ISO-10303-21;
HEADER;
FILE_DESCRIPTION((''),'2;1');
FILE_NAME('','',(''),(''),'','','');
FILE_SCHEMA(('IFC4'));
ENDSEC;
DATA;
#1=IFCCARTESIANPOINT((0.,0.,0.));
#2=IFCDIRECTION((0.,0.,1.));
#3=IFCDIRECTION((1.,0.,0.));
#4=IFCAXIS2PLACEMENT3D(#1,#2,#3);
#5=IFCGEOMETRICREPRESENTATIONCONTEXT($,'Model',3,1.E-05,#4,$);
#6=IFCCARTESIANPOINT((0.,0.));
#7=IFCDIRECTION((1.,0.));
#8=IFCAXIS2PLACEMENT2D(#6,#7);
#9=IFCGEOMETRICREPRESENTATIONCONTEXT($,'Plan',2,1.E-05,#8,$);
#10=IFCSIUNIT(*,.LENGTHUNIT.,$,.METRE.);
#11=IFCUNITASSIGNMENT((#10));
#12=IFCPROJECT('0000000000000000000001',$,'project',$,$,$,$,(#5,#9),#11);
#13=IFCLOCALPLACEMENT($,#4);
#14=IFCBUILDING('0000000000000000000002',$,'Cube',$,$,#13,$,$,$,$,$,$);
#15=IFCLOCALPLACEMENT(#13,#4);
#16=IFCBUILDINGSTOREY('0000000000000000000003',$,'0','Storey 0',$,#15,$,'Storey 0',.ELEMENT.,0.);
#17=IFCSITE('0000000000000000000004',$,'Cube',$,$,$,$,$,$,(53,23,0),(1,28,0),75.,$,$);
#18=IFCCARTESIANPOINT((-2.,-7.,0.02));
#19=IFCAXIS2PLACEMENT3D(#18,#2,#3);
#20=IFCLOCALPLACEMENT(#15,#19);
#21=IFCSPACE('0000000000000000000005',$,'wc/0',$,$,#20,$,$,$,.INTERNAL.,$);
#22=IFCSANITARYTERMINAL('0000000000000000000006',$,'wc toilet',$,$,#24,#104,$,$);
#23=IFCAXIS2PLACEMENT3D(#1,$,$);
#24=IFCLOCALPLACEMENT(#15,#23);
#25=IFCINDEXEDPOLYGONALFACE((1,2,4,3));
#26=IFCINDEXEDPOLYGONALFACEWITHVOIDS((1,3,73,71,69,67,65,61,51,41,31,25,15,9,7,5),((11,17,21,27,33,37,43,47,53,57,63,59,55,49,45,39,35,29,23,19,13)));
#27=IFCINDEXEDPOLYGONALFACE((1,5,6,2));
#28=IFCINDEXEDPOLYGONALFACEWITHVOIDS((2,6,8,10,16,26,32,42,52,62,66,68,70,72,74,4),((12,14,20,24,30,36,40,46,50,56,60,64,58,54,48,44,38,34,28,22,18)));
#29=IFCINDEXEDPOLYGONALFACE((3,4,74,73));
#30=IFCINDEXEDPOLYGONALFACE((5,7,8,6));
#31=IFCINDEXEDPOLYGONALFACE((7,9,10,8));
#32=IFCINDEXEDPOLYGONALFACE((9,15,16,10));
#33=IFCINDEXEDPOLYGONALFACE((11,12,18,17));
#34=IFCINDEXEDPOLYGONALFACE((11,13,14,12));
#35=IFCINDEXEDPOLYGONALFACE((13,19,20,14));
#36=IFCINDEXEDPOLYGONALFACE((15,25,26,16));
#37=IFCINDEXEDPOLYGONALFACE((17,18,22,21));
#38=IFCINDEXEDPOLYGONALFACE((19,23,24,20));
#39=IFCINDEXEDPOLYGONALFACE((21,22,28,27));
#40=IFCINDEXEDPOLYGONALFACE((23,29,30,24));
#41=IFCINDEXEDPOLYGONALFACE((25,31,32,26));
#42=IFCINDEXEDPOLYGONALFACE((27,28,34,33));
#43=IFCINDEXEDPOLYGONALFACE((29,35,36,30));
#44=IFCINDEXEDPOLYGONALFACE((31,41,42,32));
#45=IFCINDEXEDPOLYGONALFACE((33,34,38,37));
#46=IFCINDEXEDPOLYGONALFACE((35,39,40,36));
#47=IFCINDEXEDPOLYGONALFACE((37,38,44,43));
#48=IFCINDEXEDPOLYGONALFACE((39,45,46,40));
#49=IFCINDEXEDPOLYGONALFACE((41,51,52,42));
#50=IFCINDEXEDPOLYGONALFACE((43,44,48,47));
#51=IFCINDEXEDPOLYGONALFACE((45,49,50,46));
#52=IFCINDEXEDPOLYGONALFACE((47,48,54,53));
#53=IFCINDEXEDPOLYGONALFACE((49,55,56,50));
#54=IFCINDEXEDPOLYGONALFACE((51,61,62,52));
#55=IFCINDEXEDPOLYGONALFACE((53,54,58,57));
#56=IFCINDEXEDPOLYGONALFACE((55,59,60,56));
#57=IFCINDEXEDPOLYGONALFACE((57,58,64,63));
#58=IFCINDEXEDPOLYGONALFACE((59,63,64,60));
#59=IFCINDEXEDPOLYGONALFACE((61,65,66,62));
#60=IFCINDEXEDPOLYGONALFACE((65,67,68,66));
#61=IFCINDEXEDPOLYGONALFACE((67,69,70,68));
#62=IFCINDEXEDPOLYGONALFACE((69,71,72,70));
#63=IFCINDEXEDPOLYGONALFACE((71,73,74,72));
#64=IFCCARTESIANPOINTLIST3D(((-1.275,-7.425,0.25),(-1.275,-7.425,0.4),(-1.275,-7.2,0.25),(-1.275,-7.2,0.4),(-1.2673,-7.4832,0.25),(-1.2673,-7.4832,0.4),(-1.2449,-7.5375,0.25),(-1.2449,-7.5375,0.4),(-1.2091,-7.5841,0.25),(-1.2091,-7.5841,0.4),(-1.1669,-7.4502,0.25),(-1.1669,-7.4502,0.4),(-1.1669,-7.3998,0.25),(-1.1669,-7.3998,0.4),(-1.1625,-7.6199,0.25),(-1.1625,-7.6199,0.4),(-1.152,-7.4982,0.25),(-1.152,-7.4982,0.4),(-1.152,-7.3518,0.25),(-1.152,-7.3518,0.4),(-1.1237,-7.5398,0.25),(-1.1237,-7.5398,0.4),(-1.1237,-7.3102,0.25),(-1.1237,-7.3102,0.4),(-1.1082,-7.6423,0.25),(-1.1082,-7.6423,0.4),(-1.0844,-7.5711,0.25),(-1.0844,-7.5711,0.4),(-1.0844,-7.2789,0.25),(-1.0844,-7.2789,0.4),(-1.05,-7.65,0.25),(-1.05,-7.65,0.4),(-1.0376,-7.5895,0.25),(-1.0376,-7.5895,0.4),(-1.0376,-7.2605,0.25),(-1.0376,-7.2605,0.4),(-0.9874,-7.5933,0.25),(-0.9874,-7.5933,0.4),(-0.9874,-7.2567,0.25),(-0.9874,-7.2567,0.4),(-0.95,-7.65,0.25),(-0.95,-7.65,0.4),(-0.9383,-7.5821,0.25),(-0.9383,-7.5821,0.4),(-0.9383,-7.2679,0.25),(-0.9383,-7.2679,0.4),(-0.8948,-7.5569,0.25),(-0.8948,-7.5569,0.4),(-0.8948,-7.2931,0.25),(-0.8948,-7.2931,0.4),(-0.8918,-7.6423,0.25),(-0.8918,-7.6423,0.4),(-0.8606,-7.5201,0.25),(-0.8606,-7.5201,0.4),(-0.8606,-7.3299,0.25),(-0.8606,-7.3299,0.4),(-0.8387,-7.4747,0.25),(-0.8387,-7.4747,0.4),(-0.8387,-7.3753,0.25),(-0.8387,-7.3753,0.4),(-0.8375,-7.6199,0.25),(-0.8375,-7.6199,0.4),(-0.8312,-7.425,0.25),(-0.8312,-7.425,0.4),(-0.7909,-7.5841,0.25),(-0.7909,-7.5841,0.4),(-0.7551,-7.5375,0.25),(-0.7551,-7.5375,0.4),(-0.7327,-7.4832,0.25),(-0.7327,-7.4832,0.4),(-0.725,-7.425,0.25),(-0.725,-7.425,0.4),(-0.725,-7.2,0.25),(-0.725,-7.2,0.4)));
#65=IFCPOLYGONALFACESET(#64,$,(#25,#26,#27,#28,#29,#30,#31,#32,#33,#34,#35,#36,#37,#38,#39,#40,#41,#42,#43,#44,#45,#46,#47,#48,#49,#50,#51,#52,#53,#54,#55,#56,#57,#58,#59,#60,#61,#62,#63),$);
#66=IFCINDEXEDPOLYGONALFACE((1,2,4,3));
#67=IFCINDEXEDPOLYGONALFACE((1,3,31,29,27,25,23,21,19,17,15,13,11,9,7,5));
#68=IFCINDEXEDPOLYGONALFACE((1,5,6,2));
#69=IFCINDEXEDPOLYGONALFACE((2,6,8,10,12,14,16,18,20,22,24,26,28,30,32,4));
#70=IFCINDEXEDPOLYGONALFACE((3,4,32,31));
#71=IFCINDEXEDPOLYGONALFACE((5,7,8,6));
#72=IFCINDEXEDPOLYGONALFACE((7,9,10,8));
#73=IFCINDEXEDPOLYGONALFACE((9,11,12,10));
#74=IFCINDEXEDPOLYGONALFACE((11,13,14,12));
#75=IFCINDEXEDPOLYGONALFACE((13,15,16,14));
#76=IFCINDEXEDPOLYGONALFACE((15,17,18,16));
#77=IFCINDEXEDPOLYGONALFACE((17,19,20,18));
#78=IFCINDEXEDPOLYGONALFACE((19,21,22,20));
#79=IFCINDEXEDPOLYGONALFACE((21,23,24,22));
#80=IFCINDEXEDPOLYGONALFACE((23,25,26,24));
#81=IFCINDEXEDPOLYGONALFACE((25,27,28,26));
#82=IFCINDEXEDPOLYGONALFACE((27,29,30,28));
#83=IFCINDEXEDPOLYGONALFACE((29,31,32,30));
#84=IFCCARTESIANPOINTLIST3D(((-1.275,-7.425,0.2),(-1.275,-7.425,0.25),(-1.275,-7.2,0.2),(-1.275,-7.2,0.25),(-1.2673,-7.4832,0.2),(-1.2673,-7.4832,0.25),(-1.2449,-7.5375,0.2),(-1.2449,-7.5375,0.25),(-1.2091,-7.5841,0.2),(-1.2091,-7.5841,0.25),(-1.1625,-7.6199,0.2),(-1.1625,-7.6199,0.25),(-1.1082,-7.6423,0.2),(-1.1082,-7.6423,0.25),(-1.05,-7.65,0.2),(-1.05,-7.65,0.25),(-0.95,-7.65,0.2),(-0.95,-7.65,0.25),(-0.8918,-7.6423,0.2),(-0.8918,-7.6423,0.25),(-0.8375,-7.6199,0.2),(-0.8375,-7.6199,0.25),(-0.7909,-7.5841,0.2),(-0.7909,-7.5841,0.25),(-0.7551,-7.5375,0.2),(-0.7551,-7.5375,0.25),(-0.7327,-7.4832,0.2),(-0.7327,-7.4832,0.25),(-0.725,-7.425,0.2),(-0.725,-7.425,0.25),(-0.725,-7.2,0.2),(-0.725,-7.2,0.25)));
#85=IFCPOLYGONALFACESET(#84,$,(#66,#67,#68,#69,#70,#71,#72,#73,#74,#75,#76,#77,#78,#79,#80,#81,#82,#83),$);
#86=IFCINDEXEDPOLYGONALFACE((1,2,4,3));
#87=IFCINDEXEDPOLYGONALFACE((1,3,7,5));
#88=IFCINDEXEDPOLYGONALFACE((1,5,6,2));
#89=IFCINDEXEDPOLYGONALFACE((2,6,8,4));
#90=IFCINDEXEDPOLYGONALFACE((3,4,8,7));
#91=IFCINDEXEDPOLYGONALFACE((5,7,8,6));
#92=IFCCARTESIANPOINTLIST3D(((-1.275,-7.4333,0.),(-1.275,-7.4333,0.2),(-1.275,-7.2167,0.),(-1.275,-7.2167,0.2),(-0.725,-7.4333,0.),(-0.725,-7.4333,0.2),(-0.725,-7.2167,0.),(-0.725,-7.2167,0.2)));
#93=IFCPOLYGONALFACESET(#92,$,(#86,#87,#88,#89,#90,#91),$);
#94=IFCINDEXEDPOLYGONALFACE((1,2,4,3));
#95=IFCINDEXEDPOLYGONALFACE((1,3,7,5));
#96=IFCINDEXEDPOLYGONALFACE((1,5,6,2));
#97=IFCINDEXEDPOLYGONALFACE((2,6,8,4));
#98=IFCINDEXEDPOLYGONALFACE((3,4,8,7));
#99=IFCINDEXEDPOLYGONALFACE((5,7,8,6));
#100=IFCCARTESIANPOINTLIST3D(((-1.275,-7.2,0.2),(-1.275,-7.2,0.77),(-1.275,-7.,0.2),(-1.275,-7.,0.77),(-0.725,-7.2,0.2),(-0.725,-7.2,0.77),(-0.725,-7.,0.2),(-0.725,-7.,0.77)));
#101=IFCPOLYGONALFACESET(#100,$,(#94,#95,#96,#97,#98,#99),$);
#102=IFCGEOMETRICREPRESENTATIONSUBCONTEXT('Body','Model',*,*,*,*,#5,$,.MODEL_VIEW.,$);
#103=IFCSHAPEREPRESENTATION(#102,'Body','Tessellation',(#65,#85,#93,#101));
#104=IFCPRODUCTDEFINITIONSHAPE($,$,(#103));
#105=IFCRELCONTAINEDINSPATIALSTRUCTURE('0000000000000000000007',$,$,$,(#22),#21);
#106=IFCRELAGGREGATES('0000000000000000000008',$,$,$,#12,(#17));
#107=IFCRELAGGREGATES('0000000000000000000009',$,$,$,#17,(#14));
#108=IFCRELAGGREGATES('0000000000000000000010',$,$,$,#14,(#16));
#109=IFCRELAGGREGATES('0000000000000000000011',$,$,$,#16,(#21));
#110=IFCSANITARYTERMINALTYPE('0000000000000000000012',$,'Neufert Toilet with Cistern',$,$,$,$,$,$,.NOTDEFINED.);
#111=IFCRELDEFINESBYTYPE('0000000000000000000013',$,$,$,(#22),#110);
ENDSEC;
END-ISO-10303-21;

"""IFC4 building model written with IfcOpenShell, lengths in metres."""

from ifc_helpers import new_model, entity, si_unit, frame, frame_2d, origin_with_axes, origin_2d_with_axis, place, context, subcontext, project, spatial, line, arc, indexed_curve, circle_curve, outline, extrude, shape, source, transform, mapped, type_object, type_shapes, element, save


model = new_model("IFC4")

# Units and contexts
model_context = context("Model", 3, precision=1e-05, world=origin_with_axes())
plan_context = context("Plan", 2, precision=1e-05, world=origin_2d_with_axis())
body_context_1 = subcontext(model_context, "Body", "Model", "MODEL_VIEW")
body_context_2 = subcontext(plan_context, "Body", "Plan", "PLAN_VIEW")
ifc_project = project(units=[si_unit("LENGTHUNIT", "METRE")], contexts=[model_context, plan_context])

# Site, building, storey
site = spatial("IfcSite", under=ifc_project, Name="Cube", RefLatitude=(53, 23, 0), RefLongitude=(1, 28, 0), RefElevation=75.0)
building_placement = place(None, origin_with_axes())
building = spatial("IfcBuilding", under=site, at=building_placement, Name="Cube")
storey_placement = place(building_placement, origin_with_axes())
storey = spatial("IfcBuildingStorey", under=building, at=storey_placement, Name="0", Description="Storey 0", LongName="Storey 0", CompositionType="ELEMENT", Elevation=0.0)

# Shared definitions
space_1_placement = place(storey_placement, frame((-2.0, -7.0, 0.02), z_axis=(0.0, 0.0, 1.0), x_axis=(1.0, 0.0, 0.0)))
space_1 = spatial("IfcSpace", under=storey, at=space_1_placement, Name="wc/0", PredefinedType="INTERNAL")

# Sanitary terminal
sanitary_terminal_type_1 = type_object("IfcSanitaryTerminalType", Name="Neufert Toilet with Cistern", PredefinedType="NOTDEFINED")
shared_shape_1 = source(origin_with_axes(), body_context_1, "Body", "SweptSolid", [
    extrude(outline(indexed_curve([(-0.275, -0.2), (0.275, -0.2), (0.275, -0.425), (0.2091, -0.5841), (0.05, -0.65), (-0.05, -0.65), (-0.2091, -0.5841), (-0.275, -0.425)], segments=[line(1, 2), line(2, 3), arc(3, 4, 5), line(5, 6), arc(6, 7, 8), line(8, 1)]), holes=[circle_curve(frame_2d((0.0, -0.425)), 0.1688)]), frame((0.0, 0.0, 0.25), z_axis=(0.0, 0.0, 1.0), x_axis=(1.0, 0.0, 0.0)), (0.0, 0.0, 1.0), 0.15),
    extrude(outline(indexed_curve([(-0.275, -0.2), (0.275, -0.2), (0.275, -0.425), (0.2091, -0.5841), (0.05, -0.65), (-0.05, -0.65), (-0.2091, -0.5841), (-0.275, -0.425)], segments=[line(1, 2), line(2, 3), arc(3, 4, 5), line(5, 6), arc(6, 7, 8), line(8, 1)])), frame((0.0, 0.0, 0.2), z_axis=(0.0, 0.0, 1.0), x_axis=(1.0, 0.0, 0.0)), (0.0, 0.0, 1.0), 0.05),
    extrude(outline(indexed_curve([(-0.275, -0.2167), (0.275, -0.2167), (0.275, -0.4333), (-0.275, -0.4333)], segments=[line(1, 2, 3, 4, 1)])), origin_with_axes(), (0.0, 0.0, 1.0), 0.2),
    extrude(outline(indexed_curve([(-0.275, 0.0), (0.275, 0.0), (0.275, -0.2), (-0.275, -0.2)], segments=[line(1, 2, 3, 4, 1)])), frame((0.0, 0.0, 0.2), z_axis=(0.0, 0.0, 1.0), x_axis=(1.0, 0.0, 0.0)), (0.0, 0.0, 1.0), 0.57),
])
shared_shape_2 = source(origin_with_axes(), body_context_2, "Body", "Curve2D", [
    entity("IfcIndexedPolyCurve", entity("IfcCartesianPointList2D", [[-0.275, 0.0], [0.275, 0.0], [0.275, -0.2], [-0.275, -0.2]]), [entity("IfcLineIndex", [1, 2, 3, 4, 1])]),
    entity("IfcIndexedPolyCurve", entity("IfcCartesianPointList2D", [[0.165, -0.2], [0.1925, -0.335]])),
    entity("IfcTrimmedCurve", entity("IfcEllipse", entity("IfcAxis2Placement2D", entity("IfcCartesianPoint", [0.0, -0.335]), entity("IfcDirection", [1.0, 0.0])), 0.1925, 0.315), [entity("IfcCartesianPoint", [-0.1925, -0.335])], [entity("IfcCartesianPoint", [0.1925, -0.335])], True, "CARTESIAN"),
    entity("IfcIndexedPolyCurve", entity("IfcCartesianPointList2D", [[-0.165, -0.2], [-0.1925, -0.335]])),
    entity("IfcEllipse", entity("IfcAxis2Placement2D", entity("IfcCartesianPoint", [0.0, -0.452]), entity("IfcDirection", [1.0, 0.0])), 0.1313, 0.1575),
    entity("IfcIndexedPolyCurve", entity("IfcCartesianPointList2D", [[-0.0344, -0.452], [-0.0344, -0.4295], [0.0344, -0.4295], [0.0344, -0.452]])),
    entity("IfcTrimmedCurve", entity("IfcEllipse", entity("IfcAxis2Placement2D", entity("IfcCartesianPoint", [0.0, -0.452]), entity("IfcDirection", [1.0, 0.0])), 0.0344, 0.0225), [entity("IfcCartesianPoint", [-0.0344, -0.452])], [entity("IfcCartesianPoint", [0.0344, -0.452])], True, "CARTESIAN"),
])
type_shapes(sanitary_terminal_type_1, [shared_shape_1, shared_shape_2])
sanitary_terminal_1_placement = place(space_1_placement, frame((1.0, 0.0, -0.02), z_axis=(0.0, 0.0, 1.0), x_axis=(1.0, 0.0, 0.0)))
element("IfcSanitaryTerminal", 1, at=sanitary_terminal_1_placement, inside=space_1, type_object=sanitary_terminal_type_1, Name="wc toilet", shapes=[
    shape(body_context_1, "Body", "MappedRepresentation", [mapped(shared_shape_1, transform((0.0, 0.0, 0.0), x_axis=(1.0, 0.0, 0.0), y_axis=(0.0, 1.0, 0.0), z_axis=(0.0, 0.0, 1.0), scale=1.0))]),
    shape(body_context_2, "Body", "MappedRepresentation", [mapped(shared_shape_2, transform((0.0, 0.0, 0.0), x_axis=(1.0, 0.0, 0.0), y_axis=(0.0, 1.0, 0.0), z_axis=(0.0, 0.0, 1.0), scale=1.0))]),
])

save(model, "model.ifc")
